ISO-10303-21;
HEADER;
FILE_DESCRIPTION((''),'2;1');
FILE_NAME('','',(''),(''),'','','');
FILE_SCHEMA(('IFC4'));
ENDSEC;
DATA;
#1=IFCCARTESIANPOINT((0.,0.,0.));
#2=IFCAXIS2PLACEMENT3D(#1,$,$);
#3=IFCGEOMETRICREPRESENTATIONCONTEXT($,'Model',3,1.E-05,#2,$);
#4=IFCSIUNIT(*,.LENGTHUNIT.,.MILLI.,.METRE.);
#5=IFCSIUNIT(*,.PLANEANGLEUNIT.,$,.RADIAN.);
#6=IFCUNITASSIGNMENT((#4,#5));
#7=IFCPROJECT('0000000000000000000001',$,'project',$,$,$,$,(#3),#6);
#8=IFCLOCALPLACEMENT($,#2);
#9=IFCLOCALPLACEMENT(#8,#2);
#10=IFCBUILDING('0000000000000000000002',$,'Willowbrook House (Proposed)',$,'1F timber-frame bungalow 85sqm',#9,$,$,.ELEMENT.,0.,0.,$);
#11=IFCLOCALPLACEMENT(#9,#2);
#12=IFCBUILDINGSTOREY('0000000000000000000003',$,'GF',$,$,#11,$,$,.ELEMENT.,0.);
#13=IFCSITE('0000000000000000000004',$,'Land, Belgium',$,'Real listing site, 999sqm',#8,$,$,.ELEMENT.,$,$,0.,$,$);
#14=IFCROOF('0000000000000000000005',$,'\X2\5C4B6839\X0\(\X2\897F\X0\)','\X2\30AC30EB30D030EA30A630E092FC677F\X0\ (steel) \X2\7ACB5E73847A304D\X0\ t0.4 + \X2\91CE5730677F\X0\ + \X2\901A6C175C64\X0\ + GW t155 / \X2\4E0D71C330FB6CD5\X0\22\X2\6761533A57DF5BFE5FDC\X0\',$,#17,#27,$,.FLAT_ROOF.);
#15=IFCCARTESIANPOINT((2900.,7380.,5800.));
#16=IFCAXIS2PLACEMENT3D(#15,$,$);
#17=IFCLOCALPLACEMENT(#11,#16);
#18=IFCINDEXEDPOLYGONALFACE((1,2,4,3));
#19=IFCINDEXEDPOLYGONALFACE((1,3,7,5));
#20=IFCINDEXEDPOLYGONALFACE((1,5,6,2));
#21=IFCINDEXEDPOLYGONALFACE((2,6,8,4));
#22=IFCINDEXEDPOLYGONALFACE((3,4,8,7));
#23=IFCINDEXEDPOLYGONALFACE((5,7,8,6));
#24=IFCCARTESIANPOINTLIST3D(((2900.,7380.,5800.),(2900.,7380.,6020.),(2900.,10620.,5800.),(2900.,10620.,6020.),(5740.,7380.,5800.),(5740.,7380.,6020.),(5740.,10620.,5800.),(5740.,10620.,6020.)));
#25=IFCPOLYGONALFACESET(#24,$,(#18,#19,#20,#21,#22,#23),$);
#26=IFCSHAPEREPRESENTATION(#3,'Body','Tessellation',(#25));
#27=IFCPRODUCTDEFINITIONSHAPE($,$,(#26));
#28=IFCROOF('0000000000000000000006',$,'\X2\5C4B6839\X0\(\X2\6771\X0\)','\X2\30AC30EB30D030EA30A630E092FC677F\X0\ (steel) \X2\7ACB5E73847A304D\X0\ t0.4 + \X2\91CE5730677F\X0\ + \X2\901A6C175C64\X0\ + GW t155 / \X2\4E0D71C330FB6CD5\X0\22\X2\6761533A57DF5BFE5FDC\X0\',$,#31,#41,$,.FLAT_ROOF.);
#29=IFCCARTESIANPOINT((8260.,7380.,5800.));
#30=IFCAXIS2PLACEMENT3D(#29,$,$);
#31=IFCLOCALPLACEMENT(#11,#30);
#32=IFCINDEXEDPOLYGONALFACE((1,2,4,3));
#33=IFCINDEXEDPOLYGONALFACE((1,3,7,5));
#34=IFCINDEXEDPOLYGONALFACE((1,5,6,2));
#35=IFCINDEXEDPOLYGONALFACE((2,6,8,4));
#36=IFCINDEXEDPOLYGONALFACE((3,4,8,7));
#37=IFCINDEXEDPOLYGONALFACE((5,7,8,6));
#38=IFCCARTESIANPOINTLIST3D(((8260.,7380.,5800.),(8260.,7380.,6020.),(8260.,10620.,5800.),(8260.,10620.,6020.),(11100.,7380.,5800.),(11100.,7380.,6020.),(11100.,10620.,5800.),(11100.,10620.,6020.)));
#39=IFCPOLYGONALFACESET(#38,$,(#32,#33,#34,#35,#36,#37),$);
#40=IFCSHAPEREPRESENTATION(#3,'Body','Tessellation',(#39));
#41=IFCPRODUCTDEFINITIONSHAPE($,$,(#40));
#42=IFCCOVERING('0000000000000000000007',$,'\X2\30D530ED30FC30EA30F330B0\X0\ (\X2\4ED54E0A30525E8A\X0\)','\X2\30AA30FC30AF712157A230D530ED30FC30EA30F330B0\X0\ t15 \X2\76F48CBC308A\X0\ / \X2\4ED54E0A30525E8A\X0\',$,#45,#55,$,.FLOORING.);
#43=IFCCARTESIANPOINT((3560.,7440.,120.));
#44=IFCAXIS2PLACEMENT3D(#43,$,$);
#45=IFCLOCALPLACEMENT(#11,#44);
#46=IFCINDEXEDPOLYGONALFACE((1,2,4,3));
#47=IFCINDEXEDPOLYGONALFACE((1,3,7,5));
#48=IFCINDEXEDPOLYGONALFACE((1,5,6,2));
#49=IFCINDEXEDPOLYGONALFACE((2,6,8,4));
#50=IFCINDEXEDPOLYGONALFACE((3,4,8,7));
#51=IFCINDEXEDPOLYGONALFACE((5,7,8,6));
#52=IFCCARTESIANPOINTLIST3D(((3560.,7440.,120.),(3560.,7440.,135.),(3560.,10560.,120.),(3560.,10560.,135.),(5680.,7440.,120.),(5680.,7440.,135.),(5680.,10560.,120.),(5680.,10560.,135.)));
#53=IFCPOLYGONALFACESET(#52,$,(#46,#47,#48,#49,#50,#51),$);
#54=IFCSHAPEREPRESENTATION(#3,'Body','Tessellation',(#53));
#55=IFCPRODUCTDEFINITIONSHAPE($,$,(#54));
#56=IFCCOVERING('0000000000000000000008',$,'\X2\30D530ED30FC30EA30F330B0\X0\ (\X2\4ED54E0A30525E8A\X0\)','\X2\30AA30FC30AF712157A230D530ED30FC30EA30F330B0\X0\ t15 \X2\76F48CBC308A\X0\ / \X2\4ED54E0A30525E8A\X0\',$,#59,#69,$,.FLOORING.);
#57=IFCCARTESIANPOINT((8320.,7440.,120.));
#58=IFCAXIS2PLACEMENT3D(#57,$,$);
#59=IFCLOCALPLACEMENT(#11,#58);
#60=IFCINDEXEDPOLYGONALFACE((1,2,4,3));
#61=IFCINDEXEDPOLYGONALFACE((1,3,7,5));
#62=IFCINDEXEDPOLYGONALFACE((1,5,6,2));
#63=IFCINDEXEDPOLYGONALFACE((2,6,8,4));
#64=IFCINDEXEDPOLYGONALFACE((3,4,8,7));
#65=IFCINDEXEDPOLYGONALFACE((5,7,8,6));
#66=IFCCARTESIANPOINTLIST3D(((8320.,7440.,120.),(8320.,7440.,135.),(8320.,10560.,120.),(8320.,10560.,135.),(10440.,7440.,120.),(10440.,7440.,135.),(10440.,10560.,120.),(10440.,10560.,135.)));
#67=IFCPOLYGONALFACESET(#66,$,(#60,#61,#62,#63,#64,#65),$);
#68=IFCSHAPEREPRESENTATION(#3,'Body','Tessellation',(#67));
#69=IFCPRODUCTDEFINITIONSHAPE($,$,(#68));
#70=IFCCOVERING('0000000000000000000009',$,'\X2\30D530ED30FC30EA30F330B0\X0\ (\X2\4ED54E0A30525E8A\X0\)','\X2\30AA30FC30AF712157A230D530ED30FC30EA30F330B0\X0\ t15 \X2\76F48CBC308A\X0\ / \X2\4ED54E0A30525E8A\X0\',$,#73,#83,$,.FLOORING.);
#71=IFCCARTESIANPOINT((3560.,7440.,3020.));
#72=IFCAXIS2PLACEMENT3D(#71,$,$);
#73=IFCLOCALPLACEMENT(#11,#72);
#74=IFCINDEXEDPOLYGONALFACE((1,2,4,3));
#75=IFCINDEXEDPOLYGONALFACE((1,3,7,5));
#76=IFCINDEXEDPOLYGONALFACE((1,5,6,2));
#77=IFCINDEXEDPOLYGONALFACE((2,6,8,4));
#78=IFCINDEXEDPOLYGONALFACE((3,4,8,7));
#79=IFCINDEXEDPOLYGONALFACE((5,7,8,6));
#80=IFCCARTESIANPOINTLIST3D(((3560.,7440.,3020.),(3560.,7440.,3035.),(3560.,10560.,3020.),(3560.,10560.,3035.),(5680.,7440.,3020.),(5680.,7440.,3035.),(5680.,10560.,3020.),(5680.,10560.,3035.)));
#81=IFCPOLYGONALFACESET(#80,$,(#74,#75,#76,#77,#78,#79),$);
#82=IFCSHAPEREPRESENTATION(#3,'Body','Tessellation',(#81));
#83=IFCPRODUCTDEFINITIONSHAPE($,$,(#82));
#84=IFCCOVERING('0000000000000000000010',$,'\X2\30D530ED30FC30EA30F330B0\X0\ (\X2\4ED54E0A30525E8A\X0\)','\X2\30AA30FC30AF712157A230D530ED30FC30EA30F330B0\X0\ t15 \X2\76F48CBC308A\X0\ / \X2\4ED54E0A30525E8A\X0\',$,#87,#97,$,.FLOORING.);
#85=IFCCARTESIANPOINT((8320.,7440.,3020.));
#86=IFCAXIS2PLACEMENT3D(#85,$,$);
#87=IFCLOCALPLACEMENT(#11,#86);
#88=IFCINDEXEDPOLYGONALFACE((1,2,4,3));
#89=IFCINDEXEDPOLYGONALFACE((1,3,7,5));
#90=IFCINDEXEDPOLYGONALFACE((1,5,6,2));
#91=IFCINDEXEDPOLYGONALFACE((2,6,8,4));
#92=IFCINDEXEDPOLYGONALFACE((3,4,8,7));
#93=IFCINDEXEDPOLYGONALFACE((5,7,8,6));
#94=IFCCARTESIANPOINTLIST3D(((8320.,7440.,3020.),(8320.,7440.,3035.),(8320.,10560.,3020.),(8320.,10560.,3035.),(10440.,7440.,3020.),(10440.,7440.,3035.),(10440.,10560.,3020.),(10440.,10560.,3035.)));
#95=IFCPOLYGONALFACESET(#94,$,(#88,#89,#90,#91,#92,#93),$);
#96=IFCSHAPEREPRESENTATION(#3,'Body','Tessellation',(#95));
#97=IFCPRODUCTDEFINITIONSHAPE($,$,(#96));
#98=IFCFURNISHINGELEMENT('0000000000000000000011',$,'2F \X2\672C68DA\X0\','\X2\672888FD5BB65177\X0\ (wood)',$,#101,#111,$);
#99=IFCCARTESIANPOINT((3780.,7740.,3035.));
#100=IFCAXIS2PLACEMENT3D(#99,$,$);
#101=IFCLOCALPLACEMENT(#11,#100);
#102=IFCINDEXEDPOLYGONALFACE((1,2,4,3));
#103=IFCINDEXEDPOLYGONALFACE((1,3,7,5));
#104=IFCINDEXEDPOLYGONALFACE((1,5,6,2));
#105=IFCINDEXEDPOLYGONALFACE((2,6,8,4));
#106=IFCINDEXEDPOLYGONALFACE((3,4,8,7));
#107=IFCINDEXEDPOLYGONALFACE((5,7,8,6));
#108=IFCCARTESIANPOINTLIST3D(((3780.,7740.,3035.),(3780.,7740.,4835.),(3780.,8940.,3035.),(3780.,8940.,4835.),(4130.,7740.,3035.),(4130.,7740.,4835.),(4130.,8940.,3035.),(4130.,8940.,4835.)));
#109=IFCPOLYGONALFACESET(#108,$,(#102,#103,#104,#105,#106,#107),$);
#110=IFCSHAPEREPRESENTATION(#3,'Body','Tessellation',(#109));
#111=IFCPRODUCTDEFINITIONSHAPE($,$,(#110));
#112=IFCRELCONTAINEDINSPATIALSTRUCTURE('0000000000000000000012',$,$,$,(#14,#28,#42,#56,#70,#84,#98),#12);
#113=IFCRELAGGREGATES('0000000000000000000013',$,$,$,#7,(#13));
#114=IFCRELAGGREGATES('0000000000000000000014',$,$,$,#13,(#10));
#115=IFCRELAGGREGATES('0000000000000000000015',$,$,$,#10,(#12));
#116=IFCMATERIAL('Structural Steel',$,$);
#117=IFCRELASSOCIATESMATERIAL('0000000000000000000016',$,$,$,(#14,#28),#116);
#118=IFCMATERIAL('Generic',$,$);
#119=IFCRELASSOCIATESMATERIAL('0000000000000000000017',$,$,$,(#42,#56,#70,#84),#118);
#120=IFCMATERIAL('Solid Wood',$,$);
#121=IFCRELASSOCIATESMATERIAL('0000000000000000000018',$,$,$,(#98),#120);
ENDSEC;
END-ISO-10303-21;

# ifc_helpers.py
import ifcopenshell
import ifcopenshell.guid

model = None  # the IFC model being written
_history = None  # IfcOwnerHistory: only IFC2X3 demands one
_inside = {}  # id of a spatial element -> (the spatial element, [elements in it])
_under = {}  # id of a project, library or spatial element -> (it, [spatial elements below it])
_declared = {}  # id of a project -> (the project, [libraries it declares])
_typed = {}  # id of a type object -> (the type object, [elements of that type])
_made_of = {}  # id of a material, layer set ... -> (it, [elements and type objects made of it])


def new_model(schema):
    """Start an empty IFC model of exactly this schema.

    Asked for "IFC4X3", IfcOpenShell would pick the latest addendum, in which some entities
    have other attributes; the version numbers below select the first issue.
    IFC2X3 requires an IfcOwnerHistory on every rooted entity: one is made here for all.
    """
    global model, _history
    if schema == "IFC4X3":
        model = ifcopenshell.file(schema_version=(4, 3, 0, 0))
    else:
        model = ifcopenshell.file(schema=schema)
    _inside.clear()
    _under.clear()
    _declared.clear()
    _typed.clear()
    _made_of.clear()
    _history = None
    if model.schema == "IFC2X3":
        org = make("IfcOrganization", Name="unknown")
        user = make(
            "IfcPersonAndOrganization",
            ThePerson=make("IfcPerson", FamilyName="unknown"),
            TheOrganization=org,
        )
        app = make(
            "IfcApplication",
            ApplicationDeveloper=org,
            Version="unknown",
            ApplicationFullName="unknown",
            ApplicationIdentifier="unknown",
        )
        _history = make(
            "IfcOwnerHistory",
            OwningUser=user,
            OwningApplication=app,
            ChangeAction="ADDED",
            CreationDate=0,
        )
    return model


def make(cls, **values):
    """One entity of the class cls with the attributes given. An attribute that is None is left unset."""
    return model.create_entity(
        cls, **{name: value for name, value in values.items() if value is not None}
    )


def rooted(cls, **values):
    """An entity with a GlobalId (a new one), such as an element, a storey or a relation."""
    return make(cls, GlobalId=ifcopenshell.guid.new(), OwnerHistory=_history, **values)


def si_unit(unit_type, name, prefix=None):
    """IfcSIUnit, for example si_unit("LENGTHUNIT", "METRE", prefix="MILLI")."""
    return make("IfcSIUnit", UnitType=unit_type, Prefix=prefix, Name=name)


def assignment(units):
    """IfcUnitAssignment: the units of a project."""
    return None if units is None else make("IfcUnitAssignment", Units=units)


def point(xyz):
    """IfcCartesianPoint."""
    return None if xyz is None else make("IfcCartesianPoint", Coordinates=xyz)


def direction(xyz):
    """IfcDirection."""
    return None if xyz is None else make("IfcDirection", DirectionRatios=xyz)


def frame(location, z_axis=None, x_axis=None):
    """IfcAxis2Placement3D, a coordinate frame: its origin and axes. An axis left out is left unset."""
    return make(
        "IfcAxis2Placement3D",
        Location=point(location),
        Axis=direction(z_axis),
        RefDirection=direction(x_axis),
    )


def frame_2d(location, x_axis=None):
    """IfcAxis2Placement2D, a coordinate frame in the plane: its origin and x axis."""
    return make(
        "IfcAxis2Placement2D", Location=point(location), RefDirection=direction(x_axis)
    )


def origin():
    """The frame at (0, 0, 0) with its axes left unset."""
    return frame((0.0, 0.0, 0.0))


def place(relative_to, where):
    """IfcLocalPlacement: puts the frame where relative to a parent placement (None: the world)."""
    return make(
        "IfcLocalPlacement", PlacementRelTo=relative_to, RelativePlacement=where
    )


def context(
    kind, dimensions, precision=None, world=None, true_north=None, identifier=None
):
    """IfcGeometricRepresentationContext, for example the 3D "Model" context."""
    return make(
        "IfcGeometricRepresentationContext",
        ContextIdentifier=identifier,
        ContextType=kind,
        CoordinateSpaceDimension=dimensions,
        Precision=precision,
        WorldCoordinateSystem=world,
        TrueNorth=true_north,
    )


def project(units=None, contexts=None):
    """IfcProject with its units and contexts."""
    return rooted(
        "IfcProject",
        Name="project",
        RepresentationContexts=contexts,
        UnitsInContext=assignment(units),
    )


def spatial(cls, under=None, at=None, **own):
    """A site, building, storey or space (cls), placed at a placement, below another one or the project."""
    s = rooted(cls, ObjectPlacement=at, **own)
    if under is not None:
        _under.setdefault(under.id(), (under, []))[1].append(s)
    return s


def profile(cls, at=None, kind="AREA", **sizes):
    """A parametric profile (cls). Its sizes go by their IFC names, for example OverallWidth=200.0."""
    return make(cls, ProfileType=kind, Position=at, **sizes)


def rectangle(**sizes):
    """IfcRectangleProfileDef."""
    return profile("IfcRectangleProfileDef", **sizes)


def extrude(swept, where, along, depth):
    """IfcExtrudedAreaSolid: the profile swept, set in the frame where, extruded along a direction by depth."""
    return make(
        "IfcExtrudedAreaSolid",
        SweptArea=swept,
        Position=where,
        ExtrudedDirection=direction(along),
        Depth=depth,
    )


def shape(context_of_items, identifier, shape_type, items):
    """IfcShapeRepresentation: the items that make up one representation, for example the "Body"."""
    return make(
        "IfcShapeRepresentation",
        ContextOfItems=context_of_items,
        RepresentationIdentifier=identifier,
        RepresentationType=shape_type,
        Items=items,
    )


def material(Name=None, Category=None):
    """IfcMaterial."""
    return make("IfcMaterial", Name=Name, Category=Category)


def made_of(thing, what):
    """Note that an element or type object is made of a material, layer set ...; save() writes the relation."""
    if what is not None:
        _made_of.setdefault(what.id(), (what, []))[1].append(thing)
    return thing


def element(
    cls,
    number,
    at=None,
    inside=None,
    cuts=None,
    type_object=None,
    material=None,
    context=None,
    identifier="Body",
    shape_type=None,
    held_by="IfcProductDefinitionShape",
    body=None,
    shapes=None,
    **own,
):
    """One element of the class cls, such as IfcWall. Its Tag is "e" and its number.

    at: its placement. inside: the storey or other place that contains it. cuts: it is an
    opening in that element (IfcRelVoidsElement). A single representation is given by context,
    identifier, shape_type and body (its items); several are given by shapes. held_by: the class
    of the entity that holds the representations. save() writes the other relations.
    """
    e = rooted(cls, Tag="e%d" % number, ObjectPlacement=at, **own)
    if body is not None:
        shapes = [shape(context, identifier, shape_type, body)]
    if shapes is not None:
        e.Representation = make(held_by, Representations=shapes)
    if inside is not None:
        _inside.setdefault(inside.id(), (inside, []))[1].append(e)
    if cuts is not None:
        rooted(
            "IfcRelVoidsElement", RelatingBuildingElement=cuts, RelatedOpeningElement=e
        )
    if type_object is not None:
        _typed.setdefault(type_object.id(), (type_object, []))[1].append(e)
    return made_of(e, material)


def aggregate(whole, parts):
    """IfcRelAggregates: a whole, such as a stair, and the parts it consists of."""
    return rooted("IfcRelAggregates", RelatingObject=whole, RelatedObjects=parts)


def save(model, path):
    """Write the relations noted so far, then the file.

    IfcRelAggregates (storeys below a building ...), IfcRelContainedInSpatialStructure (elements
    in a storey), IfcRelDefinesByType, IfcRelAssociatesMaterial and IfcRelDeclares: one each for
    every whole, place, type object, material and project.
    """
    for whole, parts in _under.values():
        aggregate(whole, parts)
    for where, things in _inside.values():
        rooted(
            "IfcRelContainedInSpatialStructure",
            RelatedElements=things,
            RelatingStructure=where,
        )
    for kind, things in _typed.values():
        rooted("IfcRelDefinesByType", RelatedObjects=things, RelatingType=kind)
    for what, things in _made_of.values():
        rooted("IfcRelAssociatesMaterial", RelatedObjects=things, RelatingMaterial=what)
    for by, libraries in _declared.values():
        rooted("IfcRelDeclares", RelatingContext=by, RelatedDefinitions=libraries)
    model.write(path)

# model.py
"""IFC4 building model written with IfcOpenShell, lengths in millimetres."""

from ifc_helpers import new_model, si_unit, frame, frame_2d, origin, place, context, project, spatial, rectangle, extrude, material, element, save


model = new_model("IFC4")

# Units and contexts
model_context = context("Model", 3, precision=1e-05, world=origin())
ifc_project = project(units=[si_unit("LENGTHUNIT", "METRE", prefix="MILLI"), si_unit("PLANEANGLEUNIT", "RADIAN")], contexts=[model_context])

# Site, building, storey
site_placement = place(None, origin())
site = spatial("IfcSite", under=ifc_project, at=site_placement, Name="Land, Belgium", ObjectType="Real listing site, 999sqm", CompositionType="ELEMENT", RefElevation=0.0)
building_placement = place(site_placement, origin())
building = spatial("IfcBuilding", under=site, at=building_placement, Name="Willowbrook House (Proposed)", ObjectType="1F timber-frame bungalow 85sqm", CompositionType="ELEMENT", ElevationOfRefHeight=0.0, ElevationOfTerrain=0.0)
storey_placement = place(building_placement, origin())
storey = spatial("IfcBuildingStorey", under=building, at=storey_placement, Name="GF", CompositionType="ELEMENT", Elevation=0.0)

# Shared definitions
ifc_material_1 = material(Name="Solid Wood")

# Shared definitions
ifc_material_2 = material(Name="Generic")

# Roofs
ifc_material_3 = material(Name="Structural Steel")
roof_1_placement = place(storey_placement, frame((2900.0, 7380.0, 5800.0)))
element("IfcRoof", 1, at=roof_1_placement, inside=storey, material=ifc_material_3, Name="屋根(西)", Description="ガルバリウム鋼板 (steel) 立平葺き t0.4 + 野地板 + 通気層 + GW t155 / 不燃・法22条区域対応", PredefinedType="FLAT_ROOF", context=model_context, shape_type="SweptSolid", body=[
    extrude(rectangle(XDim=2840.0, YDim=3240.0, at=frame_2d((1420.0, 1620.0))), frame((2900.0, 7380.0, 5800.0)), (0.0, 0.0, 1.0), 220.0),
])
roof_2_placement = place(storey_placement, frame((8260.0, 7380.0, 5800.0)))
element("IfcRoof", 2, at=roof_2_placement, inside=storey, material=ifc_material_3, Name="屋根(東)", Description="ガルバリウム鋼板 (steel) 立平葺き t0.4 + 野地板 + 通気層 + GW t155 / 不燃・法22条区域対応", PredefinedType="FLAT_ROOF", context=model_context, shape_type="SweptSolid", body=[
    extrude(rectangle(XDim=2840.0, YDim=3240.0, at=frame_2d((1420.0, 1620.0))), frame((8260.0, 7380.0, 5800.0)), (0.0, 0.0, 1.0), 220.0),
])

# Coverings
covering_1_placement = place(storey_placement, frame((3560.0, 7440.0, 120.0)))
element("IfcCovering", 3, at=covering_1_placement, inside=storey, material=ifc_material_2, Name="フローリング (仕上げ床)", Description="オーク無垢フローリング t15 直貼り / 仕上げ床", PredefinedType="FLOORING", context=model_context, shape_type="SweptSolid", body=[
    extrude(rectangle(XDim=2120.0, YDim=3120.0, at=frame_2d((1060.0, 1560.0))), frame((3560.0, 7440.0, 120.0)), (0.0, 0.0, 1.0), 15.0),
])
covering_2_placement = place(storey_placement, frame((8320.0, 7440.0, 120.0)))
element("IfcCovering", 4, at=covering_2_placement, inside=storey, material=ifc_material_2, Name="フローリング (仕上げ床)", Description="オーク無垢フローリング t15 直貼り / 仕上げ床", PredefinedType="FLOORING", context=model_context, shape_type="SweptSolid", body=[
    extrude(rectangle(XDim=2120.0, YDim=3120.0, at=frame_2d((1060.0, 1560.0))), frame((8320.0, 7440.0, 120.0)), (0.0, 0.0, 1.0), 15.0),
])
covering_3_placement = place(storey_placement, frame((3560.0, 7440.0, 3020.0)))
element("IfcCovering", 5, at=covering_3_placement, inside=storey, material=ifc_material_2, Name="フローリング (仕上げ床)", Description="オーク無垢フローリング t15 直貼り / 仕上げ床", PredefinedType="FLOORING", context=model_context, shape_type="SweptSolid", body=[
    extrude(rectangle(XDim=2120.0, YDim=3120.0, at=frame_2d((1060.0, 1560.0))), frame((3560.0, 7440.0, 3020.0)), (0.0, 0.0, 1.0), 15.0),
])
covering_4_placement = place(storey_placement, frame((8320.0, 7440.0, 3020.0)))
element("IfcCovering", 6, at=covering_4_placement, inside=storey, material=ifc_material_2, Name="フローリング (仕上げ床)", Description="オーク無垢フローリング t15 直貼り / 仕上げ床", PredefinedType="FLOORING", context=model_context, shape_type="SweptSolid", body=[
    extrude(rectangle(XDim=2120.0, YDim=3120.0, at=frame_2d((1060.0, 1560.0))), frame((8320.0, 7440.0, 3020.0)), (0.0, 0.0, 1.0), 15.0),
])

# Furnishing element
furnishing_placement = place(storey_placement, frame((3780.0, 7740.0, 3035.0)))
element("IfcFurnishingElement", 7, at=furnishing_placement, inside=storey, material=ifc_material_1, Name="2F 本棚", Description="木製家具 (wood)", context=model_context, shape_type="SweptSolid", body=[
    extrude(rectangle(XDim=350.0, YDim=1200.0, at=frame_2d((175.0, 600.0))), frame((3780.0, 7740.0, 3035.0)), (0.0, 0.0, 1.0), 1800.0),
])

save(model, "model.ifc")
